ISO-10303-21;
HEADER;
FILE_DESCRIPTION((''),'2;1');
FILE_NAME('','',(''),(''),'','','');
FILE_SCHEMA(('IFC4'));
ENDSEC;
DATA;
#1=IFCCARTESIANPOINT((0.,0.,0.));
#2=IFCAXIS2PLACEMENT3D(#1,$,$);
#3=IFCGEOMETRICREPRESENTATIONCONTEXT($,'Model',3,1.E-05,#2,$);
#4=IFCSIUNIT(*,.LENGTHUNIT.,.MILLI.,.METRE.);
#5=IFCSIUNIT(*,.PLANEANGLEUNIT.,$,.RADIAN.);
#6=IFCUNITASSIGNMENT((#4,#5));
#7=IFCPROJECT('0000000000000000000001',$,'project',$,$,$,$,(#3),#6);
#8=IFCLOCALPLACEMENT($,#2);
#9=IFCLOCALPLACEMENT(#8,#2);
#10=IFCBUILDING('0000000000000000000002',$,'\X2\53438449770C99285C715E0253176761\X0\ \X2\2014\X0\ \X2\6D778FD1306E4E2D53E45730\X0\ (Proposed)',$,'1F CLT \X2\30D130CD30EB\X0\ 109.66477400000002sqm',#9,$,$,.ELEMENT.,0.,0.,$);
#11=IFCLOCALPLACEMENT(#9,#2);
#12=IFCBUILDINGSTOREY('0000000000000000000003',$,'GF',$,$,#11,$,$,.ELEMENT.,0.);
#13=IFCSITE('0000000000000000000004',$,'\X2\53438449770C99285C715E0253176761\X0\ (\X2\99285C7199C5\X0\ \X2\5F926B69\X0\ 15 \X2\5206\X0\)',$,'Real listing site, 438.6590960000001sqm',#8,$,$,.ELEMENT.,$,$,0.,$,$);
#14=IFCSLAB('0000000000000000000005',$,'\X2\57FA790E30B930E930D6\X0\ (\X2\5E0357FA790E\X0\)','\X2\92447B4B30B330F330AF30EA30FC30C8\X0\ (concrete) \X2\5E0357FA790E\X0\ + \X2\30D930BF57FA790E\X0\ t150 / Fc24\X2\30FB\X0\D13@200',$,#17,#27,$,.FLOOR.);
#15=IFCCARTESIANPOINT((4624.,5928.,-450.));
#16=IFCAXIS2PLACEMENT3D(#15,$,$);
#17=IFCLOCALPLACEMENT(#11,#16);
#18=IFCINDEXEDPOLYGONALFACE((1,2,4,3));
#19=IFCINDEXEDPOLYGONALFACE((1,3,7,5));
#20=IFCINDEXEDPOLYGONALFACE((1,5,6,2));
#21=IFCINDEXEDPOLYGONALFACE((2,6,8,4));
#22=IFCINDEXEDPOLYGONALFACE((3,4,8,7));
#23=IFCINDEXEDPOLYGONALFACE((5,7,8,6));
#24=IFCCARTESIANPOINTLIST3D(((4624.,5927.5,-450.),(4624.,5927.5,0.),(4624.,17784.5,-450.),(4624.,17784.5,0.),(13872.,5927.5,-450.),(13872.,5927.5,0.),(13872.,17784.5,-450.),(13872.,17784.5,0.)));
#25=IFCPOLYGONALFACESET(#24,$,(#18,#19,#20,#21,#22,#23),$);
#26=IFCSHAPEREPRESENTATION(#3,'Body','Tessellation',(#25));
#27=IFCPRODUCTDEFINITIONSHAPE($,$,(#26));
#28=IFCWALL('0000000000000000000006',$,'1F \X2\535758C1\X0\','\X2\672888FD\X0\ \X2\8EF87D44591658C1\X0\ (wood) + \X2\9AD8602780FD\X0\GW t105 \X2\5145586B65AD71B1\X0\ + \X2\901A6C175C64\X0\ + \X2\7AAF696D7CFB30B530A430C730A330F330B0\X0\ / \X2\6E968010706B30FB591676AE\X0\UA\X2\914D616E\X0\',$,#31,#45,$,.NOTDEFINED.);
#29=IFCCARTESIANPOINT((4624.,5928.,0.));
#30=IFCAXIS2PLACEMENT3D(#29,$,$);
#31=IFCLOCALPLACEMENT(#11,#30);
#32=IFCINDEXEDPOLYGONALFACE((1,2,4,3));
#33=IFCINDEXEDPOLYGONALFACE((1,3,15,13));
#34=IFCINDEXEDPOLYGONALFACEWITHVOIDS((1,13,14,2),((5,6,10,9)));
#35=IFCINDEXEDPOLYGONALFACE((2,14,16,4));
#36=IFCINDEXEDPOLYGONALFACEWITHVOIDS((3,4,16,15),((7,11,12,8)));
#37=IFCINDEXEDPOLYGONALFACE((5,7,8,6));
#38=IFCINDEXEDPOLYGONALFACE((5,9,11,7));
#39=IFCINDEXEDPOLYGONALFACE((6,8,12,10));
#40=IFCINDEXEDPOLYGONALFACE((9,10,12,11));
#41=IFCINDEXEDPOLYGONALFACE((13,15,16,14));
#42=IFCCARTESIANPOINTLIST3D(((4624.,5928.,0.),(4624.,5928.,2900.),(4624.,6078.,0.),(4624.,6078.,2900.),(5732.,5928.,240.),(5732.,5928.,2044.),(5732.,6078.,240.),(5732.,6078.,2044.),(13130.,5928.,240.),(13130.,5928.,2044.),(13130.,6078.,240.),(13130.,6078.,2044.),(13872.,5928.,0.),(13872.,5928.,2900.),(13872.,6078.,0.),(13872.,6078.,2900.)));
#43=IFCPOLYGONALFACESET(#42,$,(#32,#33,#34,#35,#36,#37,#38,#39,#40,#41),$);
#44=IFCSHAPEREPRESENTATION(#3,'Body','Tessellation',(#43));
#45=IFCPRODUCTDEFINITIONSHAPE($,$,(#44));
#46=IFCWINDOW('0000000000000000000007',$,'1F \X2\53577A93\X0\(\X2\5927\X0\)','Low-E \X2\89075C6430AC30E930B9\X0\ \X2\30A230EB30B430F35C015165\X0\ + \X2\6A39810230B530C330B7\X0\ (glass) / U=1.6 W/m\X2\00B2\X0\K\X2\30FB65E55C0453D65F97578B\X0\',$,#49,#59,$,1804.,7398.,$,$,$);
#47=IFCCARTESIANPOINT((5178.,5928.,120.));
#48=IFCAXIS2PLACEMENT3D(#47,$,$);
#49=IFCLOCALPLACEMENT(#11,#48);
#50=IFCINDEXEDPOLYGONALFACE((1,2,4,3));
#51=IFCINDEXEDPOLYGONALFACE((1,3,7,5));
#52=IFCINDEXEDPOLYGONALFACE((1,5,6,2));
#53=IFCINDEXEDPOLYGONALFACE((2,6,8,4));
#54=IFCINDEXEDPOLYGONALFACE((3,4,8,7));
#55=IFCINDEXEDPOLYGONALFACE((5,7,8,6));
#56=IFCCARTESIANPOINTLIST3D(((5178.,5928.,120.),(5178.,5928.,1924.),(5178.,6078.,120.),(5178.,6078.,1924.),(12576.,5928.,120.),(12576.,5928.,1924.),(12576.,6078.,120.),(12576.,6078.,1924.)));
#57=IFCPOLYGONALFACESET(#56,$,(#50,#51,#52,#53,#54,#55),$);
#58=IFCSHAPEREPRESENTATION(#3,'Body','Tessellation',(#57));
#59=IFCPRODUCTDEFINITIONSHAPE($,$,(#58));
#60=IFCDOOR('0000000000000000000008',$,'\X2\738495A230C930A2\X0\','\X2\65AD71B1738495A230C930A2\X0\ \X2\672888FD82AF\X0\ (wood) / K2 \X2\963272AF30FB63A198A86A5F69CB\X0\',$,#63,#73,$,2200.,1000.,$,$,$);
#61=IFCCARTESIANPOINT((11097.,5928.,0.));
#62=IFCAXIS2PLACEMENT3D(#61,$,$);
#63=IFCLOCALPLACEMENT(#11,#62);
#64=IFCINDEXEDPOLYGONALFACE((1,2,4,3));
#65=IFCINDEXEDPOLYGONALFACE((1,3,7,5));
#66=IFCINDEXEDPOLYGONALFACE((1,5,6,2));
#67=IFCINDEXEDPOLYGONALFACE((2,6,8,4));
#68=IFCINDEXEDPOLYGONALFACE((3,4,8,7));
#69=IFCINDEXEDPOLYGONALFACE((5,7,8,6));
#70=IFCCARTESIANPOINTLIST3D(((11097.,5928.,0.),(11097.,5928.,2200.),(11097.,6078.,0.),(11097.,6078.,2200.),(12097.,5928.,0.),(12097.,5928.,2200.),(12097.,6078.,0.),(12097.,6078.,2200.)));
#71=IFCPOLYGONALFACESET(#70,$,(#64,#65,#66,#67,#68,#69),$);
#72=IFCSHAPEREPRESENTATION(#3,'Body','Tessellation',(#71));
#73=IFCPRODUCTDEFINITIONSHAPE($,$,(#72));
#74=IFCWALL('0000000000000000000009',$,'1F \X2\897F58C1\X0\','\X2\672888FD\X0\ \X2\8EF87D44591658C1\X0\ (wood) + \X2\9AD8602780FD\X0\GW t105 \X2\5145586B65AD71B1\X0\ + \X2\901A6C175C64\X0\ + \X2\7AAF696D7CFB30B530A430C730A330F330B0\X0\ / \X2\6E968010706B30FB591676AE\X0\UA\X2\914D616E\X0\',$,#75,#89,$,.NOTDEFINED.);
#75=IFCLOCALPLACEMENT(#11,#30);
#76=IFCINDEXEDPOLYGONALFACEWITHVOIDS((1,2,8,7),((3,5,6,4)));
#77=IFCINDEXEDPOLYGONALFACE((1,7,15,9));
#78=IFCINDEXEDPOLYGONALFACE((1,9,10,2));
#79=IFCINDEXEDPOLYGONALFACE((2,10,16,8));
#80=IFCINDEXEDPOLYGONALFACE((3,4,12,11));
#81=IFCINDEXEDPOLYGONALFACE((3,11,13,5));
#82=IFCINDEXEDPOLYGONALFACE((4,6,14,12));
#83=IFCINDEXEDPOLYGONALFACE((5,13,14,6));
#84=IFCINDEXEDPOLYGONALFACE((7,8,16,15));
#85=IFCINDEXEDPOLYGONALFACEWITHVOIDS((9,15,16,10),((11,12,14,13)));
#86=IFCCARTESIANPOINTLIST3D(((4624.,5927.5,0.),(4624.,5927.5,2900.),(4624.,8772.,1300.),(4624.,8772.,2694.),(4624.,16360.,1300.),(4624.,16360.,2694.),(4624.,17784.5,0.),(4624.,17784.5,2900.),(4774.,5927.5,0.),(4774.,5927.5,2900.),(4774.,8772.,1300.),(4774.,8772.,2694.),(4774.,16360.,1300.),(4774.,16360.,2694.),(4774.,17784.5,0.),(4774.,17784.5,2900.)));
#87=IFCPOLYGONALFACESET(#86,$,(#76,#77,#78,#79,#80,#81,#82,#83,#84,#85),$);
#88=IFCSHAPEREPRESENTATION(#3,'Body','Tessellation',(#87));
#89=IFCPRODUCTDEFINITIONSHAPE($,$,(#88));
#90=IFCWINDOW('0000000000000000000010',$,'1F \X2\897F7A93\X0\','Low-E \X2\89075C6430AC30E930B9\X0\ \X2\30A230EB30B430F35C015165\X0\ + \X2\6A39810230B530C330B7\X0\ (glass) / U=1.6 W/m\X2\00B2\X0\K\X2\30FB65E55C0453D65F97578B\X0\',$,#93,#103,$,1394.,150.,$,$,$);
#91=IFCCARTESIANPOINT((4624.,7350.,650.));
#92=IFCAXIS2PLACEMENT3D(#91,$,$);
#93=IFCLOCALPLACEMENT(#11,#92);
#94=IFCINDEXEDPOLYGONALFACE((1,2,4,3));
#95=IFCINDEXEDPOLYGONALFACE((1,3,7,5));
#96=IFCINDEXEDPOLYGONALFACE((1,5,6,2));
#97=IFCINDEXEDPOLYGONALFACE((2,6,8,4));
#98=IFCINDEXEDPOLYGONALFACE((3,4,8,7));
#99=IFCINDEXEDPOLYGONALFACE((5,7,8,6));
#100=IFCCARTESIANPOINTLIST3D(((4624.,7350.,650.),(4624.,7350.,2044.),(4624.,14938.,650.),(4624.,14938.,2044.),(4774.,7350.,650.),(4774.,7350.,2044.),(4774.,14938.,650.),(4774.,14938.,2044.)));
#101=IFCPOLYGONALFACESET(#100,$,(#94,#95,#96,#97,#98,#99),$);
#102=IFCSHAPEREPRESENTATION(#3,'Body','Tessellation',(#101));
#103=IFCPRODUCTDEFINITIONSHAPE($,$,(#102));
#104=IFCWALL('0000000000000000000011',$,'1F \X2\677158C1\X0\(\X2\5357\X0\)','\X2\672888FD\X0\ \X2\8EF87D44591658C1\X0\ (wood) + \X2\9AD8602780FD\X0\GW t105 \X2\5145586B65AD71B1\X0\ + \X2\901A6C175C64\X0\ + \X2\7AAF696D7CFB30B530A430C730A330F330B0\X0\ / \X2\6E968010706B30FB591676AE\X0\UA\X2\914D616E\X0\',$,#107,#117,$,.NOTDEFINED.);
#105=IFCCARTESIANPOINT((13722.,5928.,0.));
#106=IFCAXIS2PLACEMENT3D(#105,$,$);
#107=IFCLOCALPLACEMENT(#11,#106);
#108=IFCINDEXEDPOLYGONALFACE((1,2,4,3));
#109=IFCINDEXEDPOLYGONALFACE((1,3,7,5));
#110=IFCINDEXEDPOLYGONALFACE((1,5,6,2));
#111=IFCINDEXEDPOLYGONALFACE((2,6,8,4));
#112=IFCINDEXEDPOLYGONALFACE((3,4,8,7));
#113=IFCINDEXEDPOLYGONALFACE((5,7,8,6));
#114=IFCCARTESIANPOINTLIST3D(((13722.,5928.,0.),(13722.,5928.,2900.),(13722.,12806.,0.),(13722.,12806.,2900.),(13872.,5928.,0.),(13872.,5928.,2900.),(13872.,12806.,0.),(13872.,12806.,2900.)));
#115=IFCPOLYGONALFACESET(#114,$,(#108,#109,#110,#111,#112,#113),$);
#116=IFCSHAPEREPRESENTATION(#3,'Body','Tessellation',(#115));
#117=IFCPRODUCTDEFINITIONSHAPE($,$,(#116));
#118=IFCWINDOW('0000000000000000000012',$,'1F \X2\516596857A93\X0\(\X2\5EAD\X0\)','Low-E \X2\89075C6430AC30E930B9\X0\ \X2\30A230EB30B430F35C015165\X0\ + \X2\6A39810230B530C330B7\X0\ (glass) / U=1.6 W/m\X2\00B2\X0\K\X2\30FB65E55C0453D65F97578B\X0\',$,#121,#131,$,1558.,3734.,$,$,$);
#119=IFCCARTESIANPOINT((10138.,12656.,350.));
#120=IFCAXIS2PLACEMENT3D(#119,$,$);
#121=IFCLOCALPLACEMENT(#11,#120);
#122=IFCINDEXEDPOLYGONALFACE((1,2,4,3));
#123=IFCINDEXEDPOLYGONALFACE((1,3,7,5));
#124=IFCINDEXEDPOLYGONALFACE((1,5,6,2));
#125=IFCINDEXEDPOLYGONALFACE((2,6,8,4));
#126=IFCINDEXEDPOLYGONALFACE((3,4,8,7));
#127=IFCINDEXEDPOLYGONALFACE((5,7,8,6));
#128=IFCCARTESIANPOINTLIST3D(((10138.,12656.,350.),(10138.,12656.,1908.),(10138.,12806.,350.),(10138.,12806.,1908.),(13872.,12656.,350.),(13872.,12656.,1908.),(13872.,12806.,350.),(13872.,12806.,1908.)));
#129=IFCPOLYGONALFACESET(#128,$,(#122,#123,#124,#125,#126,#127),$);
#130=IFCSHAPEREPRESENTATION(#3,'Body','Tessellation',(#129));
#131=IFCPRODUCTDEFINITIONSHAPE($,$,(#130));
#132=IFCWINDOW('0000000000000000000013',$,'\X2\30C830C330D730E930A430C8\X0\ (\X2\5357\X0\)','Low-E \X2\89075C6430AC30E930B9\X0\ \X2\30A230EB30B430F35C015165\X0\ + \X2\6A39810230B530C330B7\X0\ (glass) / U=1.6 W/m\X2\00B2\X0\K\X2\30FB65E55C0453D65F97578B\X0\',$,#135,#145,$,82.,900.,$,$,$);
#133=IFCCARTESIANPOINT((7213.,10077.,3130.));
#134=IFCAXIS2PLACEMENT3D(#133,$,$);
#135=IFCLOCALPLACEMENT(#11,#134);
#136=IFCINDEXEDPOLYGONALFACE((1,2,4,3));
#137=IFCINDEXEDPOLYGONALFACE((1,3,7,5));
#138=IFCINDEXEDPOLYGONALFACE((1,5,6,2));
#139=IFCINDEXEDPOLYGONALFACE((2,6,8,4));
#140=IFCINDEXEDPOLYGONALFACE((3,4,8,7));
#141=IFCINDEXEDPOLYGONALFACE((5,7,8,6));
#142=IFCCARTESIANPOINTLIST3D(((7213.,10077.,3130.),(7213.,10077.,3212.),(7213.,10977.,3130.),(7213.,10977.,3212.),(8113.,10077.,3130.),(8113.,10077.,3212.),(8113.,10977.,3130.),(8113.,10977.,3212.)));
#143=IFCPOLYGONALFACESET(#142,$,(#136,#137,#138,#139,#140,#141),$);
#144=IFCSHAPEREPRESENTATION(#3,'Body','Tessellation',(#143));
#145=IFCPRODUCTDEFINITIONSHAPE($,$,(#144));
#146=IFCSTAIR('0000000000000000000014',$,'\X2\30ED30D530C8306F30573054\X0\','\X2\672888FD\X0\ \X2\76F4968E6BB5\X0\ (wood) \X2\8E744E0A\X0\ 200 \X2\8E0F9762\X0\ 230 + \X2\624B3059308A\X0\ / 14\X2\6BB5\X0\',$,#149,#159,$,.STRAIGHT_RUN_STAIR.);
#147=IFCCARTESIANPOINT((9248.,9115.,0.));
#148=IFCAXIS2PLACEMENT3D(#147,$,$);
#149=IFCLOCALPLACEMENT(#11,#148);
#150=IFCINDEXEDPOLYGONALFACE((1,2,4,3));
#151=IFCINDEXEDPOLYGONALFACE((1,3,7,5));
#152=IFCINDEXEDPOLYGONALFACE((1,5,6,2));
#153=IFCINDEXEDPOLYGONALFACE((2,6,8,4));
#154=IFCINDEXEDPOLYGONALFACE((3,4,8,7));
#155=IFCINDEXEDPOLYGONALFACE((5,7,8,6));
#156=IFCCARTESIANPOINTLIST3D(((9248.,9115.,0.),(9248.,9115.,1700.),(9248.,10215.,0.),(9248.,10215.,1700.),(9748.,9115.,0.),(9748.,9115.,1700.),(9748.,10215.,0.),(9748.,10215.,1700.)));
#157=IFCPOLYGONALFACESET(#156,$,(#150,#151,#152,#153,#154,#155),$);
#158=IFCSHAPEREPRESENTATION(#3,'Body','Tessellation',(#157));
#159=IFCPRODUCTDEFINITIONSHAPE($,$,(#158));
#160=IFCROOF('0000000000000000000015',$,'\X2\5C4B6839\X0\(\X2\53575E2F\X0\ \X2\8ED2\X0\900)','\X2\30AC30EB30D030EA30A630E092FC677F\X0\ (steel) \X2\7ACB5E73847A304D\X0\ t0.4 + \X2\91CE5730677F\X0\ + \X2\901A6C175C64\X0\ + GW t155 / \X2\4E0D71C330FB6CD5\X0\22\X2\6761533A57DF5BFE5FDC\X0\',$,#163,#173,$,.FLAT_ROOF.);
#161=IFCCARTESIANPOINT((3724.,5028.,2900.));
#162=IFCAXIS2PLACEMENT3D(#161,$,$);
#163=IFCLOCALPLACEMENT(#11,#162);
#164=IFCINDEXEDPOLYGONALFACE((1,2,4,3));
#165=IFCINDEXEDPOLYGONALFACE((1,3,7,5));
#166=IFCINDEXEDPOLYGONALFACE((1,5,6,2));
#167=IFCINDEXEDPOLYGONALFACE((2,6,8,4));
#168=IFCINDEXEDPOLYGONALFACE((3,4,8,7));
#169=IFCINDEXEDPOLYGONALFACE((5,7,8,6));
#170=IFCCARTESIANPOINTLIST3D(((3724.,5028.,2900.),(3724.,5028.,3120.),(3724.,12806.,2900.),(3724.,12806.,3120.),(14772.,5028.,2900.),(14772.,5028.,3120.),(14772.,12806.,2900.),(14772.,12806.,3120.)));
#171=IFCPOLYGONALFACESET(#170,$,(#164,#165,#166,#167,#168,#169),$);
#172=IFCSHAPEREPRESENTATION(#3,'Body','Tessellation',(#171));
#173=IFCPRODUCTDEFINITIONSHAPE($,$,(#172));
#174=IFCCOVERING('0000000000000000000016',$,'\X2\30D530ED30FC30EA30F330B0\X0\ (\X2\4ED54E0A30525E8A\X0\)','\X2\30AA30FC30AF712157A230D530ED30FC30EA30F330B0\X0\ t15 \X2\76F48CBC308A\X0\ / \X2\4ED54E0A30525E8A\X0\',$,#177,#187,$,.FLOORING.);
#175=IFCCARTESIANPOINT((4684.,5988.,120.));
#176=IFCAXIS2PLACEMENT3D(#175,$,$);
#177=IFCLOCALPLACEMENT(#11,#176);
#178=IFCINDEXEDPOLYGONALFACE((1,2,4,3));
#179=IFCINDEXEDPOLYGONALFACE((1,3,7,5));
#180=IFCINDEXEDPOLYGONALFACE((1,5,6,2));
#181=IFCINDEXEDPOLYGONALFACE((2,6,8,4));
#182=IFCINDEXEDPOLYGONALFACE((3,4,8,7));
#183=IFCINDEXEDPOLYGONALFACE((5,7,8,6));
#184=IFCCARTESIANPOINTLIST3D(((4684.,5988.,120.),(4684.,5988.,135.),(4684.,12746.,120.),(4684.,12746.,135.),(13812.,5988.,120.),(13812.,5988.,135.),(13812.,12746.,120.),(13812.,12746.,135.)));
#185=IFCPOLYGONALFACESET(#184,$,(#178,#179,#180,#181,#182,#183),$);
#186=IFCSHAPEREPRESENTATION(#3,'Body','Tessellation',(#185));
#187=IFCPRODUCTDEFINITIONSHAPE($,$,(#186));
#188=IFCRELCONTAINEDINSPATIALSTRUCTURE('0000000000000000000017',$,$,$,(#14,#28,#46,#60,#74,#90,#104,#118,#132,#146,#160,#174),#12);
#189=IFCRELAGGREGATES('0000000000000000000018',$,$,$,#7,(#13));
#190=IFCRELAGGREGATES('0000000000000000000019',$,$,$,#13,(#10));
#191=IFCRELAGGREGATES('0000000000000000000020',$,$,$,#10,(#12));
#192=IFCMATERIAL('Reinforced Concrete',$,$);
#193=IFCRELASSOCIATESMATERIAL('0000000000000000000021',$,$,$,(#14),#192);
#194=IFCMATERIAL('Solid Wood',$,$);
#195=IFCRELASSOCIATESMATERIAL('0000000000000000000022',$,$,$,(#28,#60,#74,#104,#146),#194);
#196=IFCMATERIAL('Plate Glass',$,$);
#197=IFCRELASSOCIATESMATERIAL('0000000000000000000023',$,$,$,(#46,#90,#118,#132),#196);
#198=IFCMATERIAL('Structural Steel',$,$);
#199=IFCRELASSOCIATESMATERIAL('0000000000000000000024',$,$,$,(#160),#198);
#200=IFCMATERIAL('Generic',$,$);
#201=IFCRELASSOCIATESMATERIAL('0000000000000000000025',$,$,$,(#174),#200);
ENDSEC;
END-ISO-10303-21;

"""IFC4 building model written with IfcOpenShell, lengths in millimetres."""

from ifc_helpers import new_model, si_unit, frame, frame_2d, origin, place, context, project, spatial, rectangle, extrude, material, element, fill, save


model = new_model("IFC4")

# Units and contexts
model_context = context("Model", 3, precision=1e-05, world=origin())
ifc_project = project(units=[si_unit("LENGTHUNIT", "METRE", prefix="MILLI"), si_unit("PLANEANGLEUNIT", "RADIAN")], contexts=[model_context])

# Site, building, storey
site_placement = place(None, origin())
site = spatial("IfcSite", under=ifc_project, at=site_placement, Name="千葉県館山市北条 (館山駅 徒歩 15 分)", ObjectType="Real listing site, 438.6590960000001sqm", CompositionType="ELEMENT", RefElevation=0.0)
building_placement = place(site_placement, origin())
building = spatial("IfcBuilding", under=site, at=building_placement, Name="千葉県館山市北条 — 海近の中古地 (Proposed)", ObjectType="1F CLT パネル 109.66477400000002sqm", CompositionType="ELEMENT", ElevationOfRefHeight=0.0, ElevationOfTerrain=0.0)
storey_placement = place(building_placement, origin())
storey = spatial("IfcBuildingStorey", under=building, at=storey_placement, Name="GF", CompositionType="ELEMENT", Elevation=0.0)

# Slab
ifc_material_1 = material(Name="Reinforced Concrete")
slab_1_placement = place(storey_placement, frame((4624.0, 5928.0, -450.0)))
element("IfcSlab", 1, at=slab_1_placement, inside=storey, material=ifc_material_1, Name="基礎スラブ (布基礎)", Description="鉄筋コンクリート (concrete) 布基礎 + ベタ基礎 t150 / Fc24・D13@200", PredefinedType="FLOOR", context=model_context, shape_type="SweptSolid", body=[
    extrude(rectangle(XDim=9248.0, YDim=11857.0, at=frame_2d((4624.0, 5928.0))), frame((4624.0, 5928.0, -450.0)), (0.0, 0.0, 1.0), 450.0),
])
ifc_material_2 = material(Name="Solid Wood")

# Wall, openings, window, door
wall_1_placement = place(storey_placement, frame((4624.0, 5928.0, 0.0)))
wall_1 = element("IfcWall", 2, at=wall_1_placement, inside=storey, material=ifc_material_2, Name="1F 南壁", Description="木製 軸組外壁 (wood) + 高性能GW t105 充填断熱 + 通気層 + 窯業系サイディング / 準耐火・外皮UA配慮", PredefinedType="NOTDEFINED", context=model_context, shape_type="SweptSolid", body=[
    extrude(rectangle(XDim=9248.0, YDim=150.0, at=frame_2d((4624.0, 75.0))), frame((4624.0, 5928.0, 0.0)), (0.0, 0.0, 1.0), 2900.0),
])
opening_1_placement = place(storey_placement, frame((5178.0, 5928.0, 120.0)))
opening_1 = element("IfcOpeningElement", 3, at=opening_1_placement, cuts=wall_1, PredefinedType="NOTDEFINED", context=model_context, shape_type="SweptSolid", body=[
    extrude(rectangle(XDim=7398.0, YDim=150.0, at=frame_2d((3699.0, 75.0))), frame((5178.0, 5928.0, 120.0)), (0.0, 0.0, 1.0), 1804.0),
])
opening_2_placement = place(storey_placement, frame((11097.0, 5928.0, 0.0)))
opening_2 = element("IfcOpeningElement", 4, at=opening_2_placement, cuts=wall_1, PredefinedType="NOTDEFINED", context=model_context, shape_type="SweptSolid", body=[
    extrude(rectangle(XDim=1000.0, YDim=150.0, at=frame_2d((500.0, 75.0))), frame((11097.0, 5928.0, 0.0)), (0.0, 0.0, 1.0), 2200.0),
])
ifc_material_3 = material(Name="Plate Glass")
window_1_placement = place(storey_placement, frame((5178.0, 5928.0, 120.0)))
window_1 = element("IfcWindow", 5, at=window_1_placement, inside=storey, material=ifc_material_3, Name="1F 南窓(大)", Description="Low-E 複層ガラス アルゴン封入 + 樹脂サッシ (glass) / U=1.6 W/m²K・日射取得型", OverallHeight=1804.0, OverallWidth=7398.0, context=model_context, shape_type="SweptSolid", body=[
    extrude(rectangle(XDim=7398.0, YDim=150.0, at=frame_2d((3699.0, 75.0))), frame((5178.0, 5928.0, 120.0)), (0.0, 0.0, 1.0), 1804.0),
])
fill(opening_1, window_1)
door_1_placement = place(storey_placement, frame((11097.0, 5928.0, 0.0)))
door_1 = element("IfcDoor", 6, at=door_1_placement, inside=storey, material=ifc_material_2, Name="玄関ドア", Description="断熱玄関ドア 木製芯 (wood) / K2 防犯・採風機構", OverallHeight=2200.0, OverallWidth=1000.0, context=model_context, shape_type="SweptSolid", body=[
    extrude(rectangle(XDim=1000.0, YDim=150.0, at=frame_2d((500.0, 75.0))), frame((11097.0, 5928.0, 0.0)), (0.0, 0.0, 1.0), 2200.0),
])
fill(opening_2, door_1)

# Walls, openings, windows
wall_2_placement = place(storey_placement, frame((4624.0, 5928.0, 0.0)))
wall_2 = element("IfcWall", 7, at=wall_2_placement, inside=storey, material=ifc_material_2, Name="1F 西壁", Description="木製 軸組外壁 (wood) + 高性能GW t105 充填断熱 + 通気層 + 窯業系サイディング / 準耐火・外皮UA配慮", PredefinedType="NOTDEFINED", context=model_context, shape_type="SweptSolid", body=[
    extrude(rectangle(XDim=150.0, YDim=11857.0, at=frame_2d((75.0, 5928.0))), frame((4624.0, 5928.0, 0.0)), (0.0, 0.0, 1.0), 2900.0),
])
opening_3_placement = place(storey_placement, frame((4624.0, 7350.0, 650.0)))
opening_3 = element("IfcOpeningElement", 8, at=opening_3_placement, cuts=wall_2, PredefinedType="NOTDEFINED", context=model_context, shape_type="SweptSolid", body=[
    extrude(rectangle(XDim=150.0, YDim=7588.0, at=frame_2d((75.0, 3794.0))), frame((4624.0, 7350.0, 650.0)), (0.0, 0.0, 1.0), 1394.0),
])
window_2_placement = place(storey_placement, frame((4624.0, 7350.0, 650.0)))
window_2 = element("IfcWindow", 9, at=window_2_placement, inside=storey, material=ifc_material_3, Name="1F 西窓", Description="Low-E 複層ガラス アルゴン封入 + 樹脂サッシ (glass) / U=1.6 W/m²K・日射取得型", OverallHeight=1394.0, OverallWidth=150.0, context=model_context, shape_type="SweptSolid", body=[
    extrude(rectangle(XDim=150.0, YDim=7588.0, at=frame_2d((75.0, 3794.0))), frame((4624.0, 7350.0, 650.0)), (0.0, 0.0, 1.0), 1394.0),
])
fill(opening_3, window_2)
wall_3_placement = place(storey_placement, frame((13722.0, 5928.0, 0.0)))
wall_3 = element("IfcWall", 10, at=wall_3_placement, inside=storey, material=ifc_material_2, Name="1F 東壁(南)", Description="木製 軸組外壁 (wood) + 高性能GW t105 充填断熱 + 通気層 + 窯業系サイディング / 準耐火・外皮UA配慮", PredefinedType="NOTDEFINED", context=model_context, shape_type="SweptSolid", body=[
    extrude(rectangle(XDim=150.0, YDim=6878.0, at=frame_2d((75.0, 3439.0))), frame((13722.0, 5928.0, 0.0)), (0.0, 0.0, 1.0), 2900.0),
])
opening_4_placement = place(storey_placement, frame((10138.0, 12656.0, 350.0)))
opening_4 = element("IfcOpeningElement", 11, at=opening_4_placement, cuts=wall_3, PredefinedType="NOTDEFINED", context=model_context, shape_type="SweptSolid", body=[
    extrude(rectangle(XDim=3734.0, YDim=150.0, at=frame_2d((1867.0, 75.0))), frame((10138.0, 12656.0, 350.0)), (0.0, 0.0, 1.0), 1558.0),
])
window_3_placement = place(storey_placement, frame((10138.0, 12656.0, 350.0)))
window_3 = element("IfcWindow", 12, at=window_3_placement, inside=storey, material=ifc_material_3, Name="1F 入隅窓(庭)", Description="Low-E 複層ガラス アルゴン封入 + 樹脂サッシ (glass) / U=1.6 W/m²K・日射取得型", OverallHeight=1558.0, OverallWidth=3734.0, context=model_context, shape_type="SweptSolid", body=[
    extrude(rectangle(XDim=3734.0, YDim=150.0, at=frame_2d((1867.0, 75.0))), frame((10138.0, 12656.0, 350.0)), (0.0, 0.0, 1.0), 1558.0),
])
fill(opening_4, window_3)

# Window
window_4_placement = place(storey_placement, frame((7213.0, 10077.0, 3130.0)))
element("IfcWindow", 13, at=window_4_placement, inside=storey, material=ifc_material_3, Name="トップライト (南)", Description="Low-E 複層ガラス アルゴン封入 + 樹脂サッシ (glass) / U=1.6 W/m²K・日射取得型", OverallHeight=82.0, OverallWidth=900.0, context=model_context, shape_type="SweptSolid", body=[
    extrude(rectangle(XDim=900.0, YDim=900.0, at=frame_2d((450.0, 450.0))), frame((7213.0, 10077.0, 3130.0)), (0.0, 0.0, 1.0), 82.0),
])

# Stair
stair_placement = place(storey_placement, frame((9248.0, 9115.0, 0.0)))
element("IfcStair", 14, at=stair_placement, inside=storey, material=ifc_material_2, Name="ロフトはしご", Description="木製 直階段 (wood) 蹴上 200 踏面 230 + 手すり / 14段", PredefinedType="STRAIGHT_RUN_STAIR", context=model_context, shape_type="SweptSolid", body=[
    extrude(rectangle(XDim=500.0, YDim=1100.0, at=frame_2d((250.0, 550.0))), frame((9248.0, 9115.0, 0.0)), (0.0, 0.0, 1.0), 1700.0),
])

# Roof
ifc_material_4 = material(Name="Structural Steel")
roof_placement = place(storey_placement, frame((3724.0, 5028.0, 2900.0)))
element("IfcRoof", 15, at=roof_placement, inside=storey, material=ifc_material_4, Name="屋根(南帯 軒900)", Description="ガルバリウム鋼板 (steel) 立平葺き t0.4 + 野地板 + 通気層 + GW t155 / 不燃・法22条区域対応", PredefinedType="FLAT_ROOF", context=model_context, shape_type="SweptSolid", body=[
    extrude(rectangle(XDim=11048.0, YDim=7778.0, at=frame_2d((5524.0, 3889.0))), frame((3724.0, 5028.0, 2900.0)), (0.0, 0.0, 1.0), 220.0),
])

# Covering
ifc_material_5 = material(Name="Generic")
covering_placement = place(storey_placement, frame((4684.0, 5988.0, 120.0)))
element("IfcCovering", 16, at=covering_placement, inside=storey, material=ifc_material_5, Name="フローリング (仕上げ床)", Description="オーク無垢フローリング t15 直貼り / 仕上げ床", PredefinedType="FLOORING", context=model_context, shape_type="SweptSolid", body=[
    extrude(rectangle(XDim=9128.0, YDim=6758.0, at=frame_2d((4564.0, 3379.0))), frame((4684.0, 5988.0, 120.0)), (0.0, 0.0, 1.0), 15.0),
])

save(model, "model.ifc")
